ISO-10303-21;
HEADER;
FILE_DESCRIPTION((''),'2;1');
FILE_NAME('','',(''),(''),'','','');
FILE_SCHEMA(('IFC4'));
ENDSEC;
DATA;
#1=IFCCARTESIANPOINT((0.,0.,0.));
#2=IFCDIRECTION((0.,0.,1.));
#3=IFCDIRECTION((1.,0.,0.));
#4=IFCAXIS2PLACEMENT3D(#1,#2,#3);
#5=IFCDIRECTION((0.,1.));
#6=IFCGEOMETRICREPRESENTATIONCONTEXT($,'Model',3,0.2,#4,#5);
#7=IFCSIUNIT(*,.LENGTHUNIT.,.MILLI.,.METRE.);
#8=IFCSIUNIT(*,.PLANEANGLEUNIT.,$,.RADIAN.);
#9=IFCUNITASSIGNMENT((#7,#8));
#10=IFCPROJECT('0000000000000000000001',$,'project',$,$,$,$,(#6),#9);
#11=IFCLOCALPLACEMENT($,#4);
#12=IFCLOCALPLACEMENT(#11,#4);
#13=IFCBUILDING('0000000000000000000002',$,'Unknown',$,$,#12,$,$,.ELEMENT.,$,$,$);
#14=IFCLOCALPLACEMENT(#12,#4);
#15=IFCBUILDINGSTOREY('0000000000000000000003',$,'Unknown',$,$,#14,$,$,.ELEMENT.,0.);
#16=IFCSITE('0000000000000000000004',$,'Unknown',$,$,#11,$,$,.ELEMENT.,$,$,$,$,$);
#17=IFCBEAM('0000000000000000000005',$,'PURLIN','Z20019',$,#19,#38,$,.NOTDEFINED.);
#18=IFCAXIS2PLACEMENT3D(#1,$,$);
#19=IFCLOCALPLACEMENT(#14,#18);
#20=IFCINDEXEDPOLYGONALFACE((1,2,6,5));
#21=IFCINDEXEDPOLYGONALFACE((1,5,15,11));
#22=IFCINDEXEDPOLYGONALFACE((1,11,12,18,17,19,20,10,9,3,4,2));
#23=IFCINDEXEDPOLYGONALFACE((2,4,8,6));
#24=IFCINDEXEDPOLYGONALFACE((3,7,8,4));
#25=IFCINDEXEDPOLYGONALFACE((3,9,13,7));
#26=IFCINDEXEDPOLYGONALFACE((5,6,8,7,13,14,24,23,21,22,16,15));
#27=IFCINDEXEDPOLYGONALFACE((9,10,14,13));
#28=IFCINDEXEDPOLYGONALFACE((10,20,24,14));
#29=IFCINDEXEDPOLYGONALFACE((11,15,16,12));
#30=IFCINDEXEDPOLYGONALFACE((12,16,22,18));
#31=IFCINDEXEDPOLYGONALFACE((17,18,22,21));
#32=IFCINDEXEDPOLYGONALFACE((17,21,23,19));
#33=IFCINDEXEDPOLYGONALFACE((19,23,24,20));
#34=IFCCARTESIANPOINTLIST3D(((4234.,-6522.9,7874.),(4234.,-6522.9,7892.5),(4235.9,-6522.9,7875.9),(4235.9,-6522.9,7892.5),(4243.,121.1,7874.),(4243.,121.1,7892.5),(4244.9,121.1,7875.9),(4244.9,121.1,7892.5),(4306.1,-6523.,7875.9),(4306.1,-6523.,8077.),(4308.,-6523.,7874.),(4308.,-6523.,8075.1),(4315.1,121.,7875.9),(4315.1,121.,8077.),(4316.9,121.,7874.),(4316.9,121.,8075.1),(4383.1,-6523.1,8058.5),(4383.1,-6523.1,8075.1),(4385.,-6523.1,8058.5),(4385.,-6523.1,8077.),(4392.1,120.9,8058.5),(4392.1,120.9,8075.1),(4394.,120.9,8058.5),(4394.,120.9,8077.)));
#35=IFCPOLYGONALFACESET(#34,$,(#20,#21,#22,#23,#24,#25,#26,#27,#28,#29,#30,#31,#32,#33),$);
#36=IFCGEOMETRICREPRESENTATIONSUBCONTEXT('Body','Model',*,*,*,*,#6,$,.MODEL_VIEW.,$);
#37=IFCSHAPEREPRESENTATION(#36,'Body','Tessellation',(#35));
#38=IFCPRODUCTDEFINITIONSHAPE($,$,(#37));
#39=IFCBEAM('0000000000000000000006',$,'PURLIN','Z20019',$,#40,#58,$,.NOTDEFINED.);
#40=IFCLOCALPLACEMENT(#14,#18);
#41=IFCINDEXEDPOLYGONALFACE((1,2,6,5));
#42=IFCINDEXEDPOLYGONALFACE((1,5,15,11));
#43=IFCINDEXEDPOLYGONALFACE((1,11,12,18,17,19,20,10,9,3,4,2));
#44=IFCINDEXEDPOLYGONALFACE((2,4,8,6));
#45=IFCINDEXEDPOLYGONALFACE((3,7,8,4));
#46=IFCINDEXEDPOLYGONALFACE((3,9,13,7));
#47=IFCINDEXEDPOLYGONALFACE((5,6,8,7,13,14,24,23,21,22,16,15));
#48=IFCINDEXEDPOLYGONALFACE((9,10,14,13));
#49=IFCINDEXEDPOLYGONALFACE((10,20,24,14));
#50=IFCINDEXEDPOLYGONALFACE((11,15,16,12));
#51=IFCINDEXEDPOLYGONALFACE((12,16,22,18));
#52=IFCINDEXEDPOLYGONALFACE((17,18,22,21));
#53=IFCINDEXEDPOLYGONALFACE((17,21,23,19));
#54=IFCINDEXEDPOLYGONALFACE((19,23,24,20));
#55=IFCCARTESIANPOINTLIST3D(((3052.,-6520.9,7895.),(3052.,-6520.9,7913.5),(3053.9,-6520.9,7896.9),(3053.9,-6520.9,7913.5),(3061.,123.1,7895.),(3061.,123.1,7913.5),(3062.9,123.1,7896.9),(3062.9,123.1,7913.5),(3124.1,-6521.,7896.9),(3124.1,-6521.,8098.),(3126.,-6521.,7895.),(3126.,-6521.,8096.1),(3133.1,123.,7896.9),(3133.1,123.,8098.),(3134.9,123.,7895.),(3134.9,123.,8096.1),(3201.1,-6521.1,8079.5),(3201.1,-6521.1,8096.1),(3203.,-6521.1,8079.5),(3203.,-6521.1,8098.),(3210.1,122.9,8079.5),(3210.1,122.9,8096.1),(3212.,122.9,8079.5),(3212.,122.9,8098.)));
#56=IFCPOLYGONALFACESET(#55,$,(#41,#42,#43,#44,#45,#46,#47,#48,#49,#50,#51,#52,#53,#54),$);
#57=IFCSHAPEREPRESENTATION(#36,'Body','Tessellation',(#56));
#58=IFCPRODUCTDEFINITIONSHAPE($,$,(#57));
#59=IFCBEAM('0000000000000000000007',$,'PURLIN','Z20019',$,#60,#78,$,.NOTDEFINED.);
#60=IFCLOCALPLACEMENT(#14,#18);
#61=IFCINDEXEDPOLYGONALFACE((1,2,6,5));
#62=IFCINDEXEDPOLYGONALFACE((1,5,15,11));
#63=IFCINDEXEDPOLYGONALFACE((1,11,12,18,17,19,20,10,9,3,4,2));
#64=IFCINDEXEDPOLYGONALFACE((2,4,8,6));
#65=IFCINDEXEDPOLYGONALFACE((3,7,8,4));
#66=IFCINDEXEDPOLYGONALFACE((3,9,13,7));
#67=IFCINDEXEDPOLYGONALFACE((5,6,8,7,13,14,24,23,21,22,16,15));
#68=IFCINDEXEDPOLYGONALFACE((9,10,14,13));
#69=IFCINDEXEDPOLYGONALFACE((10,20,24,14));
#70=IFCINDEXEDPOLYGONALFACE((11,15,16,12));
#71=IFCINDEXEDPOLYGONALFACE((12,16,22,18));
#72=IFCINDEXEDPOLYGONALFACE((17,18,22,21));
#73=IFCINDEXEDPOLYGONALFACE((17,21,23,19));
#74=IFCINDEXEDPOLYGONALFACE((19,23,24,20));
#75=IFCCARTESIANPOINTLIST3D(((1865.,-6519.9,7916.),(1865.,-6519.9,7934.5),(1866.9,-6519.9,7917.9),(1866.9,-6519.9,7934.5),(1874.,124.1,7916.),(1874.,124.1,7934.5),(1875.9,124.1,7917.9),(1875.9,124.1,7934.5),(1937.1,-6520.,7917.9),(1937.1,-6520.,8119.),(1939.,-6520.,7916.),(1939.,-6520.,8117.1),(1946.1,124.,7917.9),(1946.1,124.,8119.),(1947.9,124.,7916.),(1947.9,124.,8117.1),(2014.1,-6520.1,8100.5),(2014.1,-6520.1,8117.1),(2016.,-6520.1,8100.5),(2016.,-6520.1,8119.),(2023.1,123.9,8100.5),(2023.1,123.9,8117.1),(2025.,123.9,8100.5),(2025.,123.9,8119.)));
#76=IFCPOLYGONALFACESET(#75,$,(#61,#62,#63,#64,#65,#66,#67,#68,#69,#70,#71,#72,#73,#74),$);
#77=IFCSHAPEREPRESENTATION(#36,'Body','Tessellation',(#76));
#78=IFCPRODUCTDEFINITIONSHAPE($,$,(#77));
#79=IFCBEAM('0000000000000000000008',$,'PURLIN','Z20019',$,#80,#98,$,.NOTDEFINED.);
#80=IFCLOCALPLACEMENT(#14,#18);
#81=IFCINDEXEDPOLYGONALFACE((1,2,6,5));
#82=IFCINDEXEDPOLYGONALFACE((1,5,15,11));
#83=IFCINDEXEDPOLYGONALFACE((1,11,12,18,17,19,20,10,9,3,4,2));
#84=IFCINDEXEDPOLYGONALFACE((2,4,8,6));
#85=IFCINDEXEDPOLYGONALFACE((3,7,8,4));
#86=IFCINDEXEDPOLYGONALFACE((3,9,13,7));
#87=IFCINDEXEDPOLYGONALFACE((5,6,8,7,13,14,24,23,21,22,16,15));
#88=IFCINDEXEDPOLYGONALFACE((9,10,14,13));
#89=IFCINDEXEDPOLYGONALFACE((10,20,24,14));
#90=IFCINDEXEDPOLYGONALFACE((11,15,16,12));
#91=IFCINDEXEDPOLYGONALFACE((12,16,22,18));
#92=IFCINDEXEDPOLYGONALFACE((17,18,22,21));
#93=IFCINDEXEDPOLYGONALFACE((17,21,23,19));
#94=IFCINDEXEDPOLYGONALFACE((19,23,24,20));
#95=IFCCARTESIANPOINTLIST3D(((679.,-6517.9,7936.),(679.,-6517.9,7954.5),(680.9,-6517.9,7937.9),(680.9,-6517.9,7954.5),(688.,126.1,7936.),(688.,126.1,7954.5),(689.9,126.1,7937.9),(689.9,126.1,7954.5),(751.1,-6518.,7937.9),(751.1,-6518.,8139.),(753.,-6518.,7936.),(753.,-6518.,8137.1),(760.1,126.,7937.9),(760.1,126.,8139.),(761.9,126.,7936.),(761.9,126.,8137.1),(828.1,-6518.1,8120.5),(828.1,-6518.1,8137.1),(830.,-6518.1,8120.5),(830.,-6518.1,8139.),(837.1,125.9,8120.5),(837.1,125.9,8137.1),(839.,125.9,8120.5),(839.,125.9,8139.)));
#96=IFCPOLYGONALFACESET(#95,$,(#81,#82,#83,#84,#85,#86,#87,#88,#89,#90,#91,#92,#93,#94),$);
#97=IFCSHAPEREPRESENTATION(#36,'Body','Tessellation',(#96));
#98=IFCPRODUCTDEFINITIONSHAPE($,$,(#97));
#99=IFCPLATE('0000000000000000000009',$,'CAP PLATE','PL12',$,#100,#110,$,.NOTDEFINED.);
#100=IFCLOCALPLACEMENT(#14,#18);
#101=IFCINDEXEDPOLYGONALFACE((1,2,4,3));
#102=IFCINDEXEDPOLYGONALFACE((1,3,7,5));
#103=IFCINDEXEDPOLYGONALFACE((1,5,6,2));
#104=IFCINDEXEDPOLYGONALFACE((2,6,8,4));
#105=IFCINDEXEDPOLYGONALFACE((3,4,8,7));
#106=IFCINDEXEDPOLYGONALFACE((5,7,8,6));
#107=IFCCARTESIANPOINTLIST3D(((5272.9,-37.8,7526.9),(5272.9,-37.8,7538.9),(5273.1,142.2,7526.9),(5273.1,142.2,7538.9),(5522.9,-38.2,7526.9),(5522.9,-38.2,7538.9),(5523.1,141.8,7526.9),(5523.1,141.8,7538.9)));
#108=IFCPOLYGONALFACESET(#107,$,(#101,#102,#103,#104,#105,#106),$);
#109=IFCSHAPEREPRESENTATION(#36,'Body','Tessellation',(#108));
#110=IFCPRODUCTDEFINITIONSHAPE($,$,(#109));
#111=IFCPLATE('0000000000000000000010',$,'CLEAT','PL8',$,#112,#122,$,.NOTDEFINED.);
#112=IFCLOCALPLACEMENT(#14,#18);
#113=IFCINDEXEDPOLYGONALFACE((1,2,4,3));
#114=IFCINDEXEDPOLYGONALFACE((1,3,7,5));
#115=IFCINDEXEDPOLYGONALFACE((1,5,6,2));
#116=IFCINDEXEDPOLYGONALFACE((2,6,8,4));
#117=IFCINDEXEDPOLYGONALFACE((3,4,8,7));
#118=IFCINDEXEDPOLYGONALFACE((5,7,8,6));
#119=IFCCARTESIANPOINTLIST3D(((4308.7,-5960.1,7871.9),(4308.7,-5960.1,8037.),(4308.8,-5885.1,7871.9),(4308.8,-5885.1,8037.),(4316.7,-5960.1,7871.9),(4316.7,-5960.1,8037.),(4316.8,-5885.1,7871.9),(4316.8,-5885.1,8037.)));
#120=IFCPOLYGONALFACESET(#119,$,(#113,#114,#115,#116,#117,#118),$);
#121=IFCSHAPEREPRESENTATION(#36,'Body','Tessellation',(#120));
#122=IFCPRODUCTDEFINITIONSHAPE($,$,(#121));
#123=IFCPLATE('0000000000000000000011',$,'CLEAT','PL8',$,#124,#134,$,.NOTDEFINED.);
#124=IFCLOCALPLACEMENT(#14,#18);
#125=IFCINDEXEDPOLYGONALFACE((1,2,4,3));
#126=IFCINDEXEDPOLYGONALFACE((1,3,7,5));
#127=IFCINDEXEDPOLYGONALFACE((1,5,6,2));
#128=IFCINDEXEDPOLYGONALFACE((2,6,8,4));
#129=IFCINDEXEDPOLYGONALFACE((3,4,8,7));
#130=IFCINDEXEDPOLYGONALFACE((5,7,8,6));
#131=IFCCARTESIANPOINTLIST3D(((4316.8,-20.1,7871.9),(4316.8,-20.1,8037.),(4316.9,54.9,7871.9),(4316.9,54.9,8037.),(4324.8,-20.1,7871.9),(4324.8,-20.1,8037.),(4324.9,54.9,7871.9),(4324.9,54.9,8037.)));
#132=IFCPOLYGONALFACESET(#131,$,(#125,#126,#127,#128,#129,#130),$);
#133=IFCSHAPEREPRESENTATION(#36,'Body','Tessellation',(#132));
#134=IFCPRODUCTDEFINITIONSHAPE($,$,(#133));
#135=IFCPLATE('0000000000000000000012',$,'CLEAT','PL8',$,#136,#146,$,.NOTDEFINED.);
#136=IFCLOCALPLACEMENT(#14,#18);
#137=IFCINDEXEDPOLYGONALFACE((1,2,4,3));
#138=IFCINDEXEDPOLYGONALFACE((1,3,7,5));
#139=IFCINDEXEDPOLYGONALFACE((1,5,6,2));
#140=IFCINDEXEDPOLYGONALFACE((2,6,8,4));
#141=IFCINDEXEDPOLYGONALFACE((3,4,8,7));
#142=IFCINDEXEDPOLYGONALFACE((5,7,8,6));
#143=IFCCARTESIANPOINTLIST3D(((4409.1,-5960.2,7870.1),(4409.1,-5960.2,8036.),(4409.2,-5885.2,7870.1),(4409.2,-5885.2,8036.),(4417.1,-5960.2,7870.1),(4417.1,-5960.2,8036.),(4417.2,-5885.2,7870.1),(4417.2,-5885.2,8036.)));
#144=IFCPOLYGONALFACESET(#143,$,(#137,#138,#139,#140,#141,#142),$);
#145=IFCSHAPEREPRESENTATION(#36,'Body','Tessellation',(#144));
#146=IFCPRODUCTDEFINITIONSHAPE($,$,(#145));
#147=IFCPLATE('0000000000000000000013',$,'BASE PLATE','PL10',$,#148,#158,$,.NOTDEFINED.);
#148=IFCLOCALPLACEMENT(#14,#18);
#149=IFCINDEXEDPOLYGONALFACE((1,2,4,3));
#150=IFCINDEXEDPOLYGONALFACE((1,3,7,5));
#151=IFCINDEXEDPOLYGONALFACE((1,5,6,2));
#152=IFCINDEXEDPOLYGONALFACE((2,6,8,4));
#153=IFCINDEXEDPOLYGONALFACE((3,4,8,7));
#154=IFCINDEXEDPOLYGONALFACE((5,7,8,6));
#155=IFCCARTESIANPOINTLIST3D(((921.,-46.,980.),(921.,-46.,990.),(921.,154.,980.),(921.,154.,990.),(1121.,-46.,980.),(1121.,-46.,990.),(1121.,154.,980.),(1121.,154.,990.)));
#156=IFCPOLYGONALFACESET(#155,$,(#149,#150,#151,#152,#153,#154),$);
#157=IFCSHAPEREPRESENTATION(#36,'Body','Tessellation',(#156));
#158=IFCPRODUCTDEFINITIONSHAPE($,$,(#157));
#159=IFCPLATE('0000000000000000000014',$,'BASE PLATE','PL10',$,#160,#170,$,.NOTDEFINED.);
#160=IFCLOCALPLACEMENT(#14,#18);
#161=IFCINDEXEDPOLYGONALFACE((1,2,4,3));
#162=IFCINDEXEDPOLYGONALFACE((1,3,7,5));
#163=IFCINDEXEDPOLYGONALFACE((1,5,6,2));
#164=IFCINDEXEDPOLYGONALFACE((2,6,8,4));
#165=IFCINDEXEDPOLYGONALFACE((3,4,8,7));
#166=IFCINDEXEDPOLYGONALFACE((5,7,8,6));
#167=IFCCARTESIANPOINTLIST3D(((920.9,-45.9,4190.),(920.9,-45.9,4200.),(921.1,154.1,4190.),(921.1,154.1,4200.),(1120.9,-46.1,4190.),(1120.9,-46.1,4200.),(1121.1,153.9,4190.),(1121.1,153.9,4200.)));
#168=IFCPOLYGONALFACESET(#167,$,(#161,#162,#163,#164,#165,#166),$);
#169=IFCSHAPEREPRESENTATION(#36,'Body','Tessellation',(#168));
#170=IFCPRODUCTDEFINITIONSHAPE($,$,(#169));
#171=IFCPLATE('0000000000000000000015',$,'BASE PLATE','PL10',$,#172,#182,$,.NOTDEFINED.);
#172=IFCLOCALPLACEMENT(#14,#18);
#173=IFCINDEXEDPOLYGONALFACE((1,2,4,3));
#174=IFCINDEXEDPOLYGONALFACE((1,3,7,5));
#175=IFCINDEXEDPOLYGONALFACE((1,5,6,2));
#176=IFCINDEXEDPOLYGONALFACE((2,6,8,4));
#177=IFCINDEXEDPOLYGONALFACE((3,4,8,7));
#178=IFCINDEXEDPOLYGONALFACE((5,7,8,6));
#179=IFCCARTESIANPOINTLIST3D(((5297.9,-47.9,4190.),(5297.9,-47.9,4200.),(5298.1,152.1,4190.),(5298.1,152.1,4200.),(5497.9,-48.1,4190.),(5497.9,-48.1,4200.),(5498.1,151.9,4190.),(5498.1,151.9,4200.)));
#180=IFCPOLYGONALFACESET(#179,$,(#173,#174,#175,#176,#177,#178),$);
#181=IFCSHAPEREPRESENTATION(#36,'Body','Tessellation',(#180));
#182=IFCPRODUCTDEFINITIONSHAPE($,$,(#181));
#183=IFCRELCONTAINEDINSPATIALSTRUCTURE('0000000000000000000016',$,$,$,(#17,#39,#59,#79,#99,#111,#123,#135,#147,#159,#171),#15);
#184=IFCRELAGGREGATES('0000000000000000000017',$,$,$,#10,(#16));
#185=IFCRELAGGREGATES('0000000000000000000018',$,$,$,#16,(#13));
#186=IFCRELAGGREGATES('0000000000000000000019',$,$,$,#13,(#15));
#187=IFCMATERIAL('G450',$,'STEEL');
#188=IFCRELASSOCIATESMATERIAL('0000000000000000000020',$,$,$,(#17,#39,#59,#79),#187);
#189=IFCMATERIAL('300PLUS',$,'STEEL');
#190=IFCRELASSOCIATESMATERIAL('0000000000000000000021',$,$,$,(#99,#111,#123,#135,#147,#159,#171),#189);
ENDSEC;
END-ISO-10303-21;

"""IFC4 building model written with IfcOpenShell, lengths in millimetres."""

from ifc_helpers import new_model, si_unit, direction, frame, origin_with_axes, place, context, subcontext, project, spatial, line, indexed_curve, outline, extrude, material, element, save


model = new_model("IFC4")

# Units and contexts
model_context = context("Model", 3, precision=0.2, world=origin_with_axes(), true_north=direction((0.0, 1.0)))
body_context = subcontext(model_context, "Body", "Model", "MODEL_VIEW")
ifc_project = project(units=[si_unit("LENGTHUNIT", "METRE", prefix="MILLI"), si_unit("PLANEANGLEUNIT", "RADIAN")], contexts=[model_context])

# Site, building, storey
site_placement = place(None, origin_with_axes())
site = spatial("IfcSite", under=ifc_project, at=site_placement, Name="Unknown", CompositionType="ELEMENT")
building_placement = place(site_placement, origin_with_axes())
building = spatial("IfcBuilding", under=site, at=building_placement, Name="Unknown", CompositionType="ELEMENT")
storey_placement = place(building_placement, origin_with_axes())
storey = spatial("IfcBuildingStorey", under=building, at=storey_placement, Name="Unknown", CompositionType="ELEMENT", Elevation=0.0)

# Beams
ifc_material_1 = material(Name="G450", Category="STEEL")
for number, where, z_axis, x_axis, name in (
    (1, (4316.0, 121.0, 7975.5), (-0.999999, 0.001355, 0.0), (-0.001355, -0.999999, 0.0), "PURLIN"),
    (2, (3134.0, 123.0, 7996.5), (-0.999999, 0.001355, 0.0), (-0.001355, -0.999999, 0.0), "PURLIN"),
    (3, (1947.0, 124.0, 8017.5), (-0.999999, 0.001355, 0.0), (-0.001355, -0.999999, 0.0), "PURLIN"),
    (4, (761.0, 126.0, 8037.5), (-0.999999, 0.001355, 0.0), (-0.001355, -0.999999, 0.0), "PURLIN"),
):
    element("IfcBeam", number, at=place(storey_placement, frame(where, z_axis=z_axis, x_axis=x_axis)), inside=storey, material=ifc_material_1, Name=name, Description="Z20019", PredefinedType="NOTDEFINED", context=body_context, shape_type="SolidModel", body=[
        extrude(outline(indexed_curve([(73.0, -101.5), (73.0, -83.0), (71.2, -83.0), (71.2, -99.6), (0.9, -99.6), (0.9, 101.5), (-78.0, 101.5), (-78.0, 83.0), (-76.2, 83.0), (-76.2, 99.6), (-0.9, 99.6), (-0.9, -101.5)], segments=[line(1, 2, 3, 4, 5, 6, 7, 8, 9, 10, 11, 12, 1)])), frame((0.0, 0.0, 0.0), z_axis=(-1.0, 0.0, 0.0), x_axis=(0.0, 0.0, 1.0)), (0.0, 0.0, -1.0), 6644.0),
    ])

# Plates
ifc_material_2 = material(Name="300PLUS", Category="STEEL")
plate_1_placement = place(storey_placement, frame((5272.9, -37.8, 7532.9), z_axis=(0.0, 0.0, 1.0), x_axis=(0.999999, -0.0016, 0.0)))
element("IfcPlate", 5, at=plate_1_placement, inside=storey, material=ifc_material_2, Name="CAP PLATE", Description="PL12", PredefinedType="NOTDEFINED", context=body_context, shape_type="SolidModel", body=[
    extrude(outline(indexed_curve([(0.0, 0.0), (250.0, 0.0), (249.9, 180.0), (-0.1, 180.0)], segments=[line(1, 2, 3, 4, 1)])), frame((0.0, 0.0, 6.0), z_axis=(0.0, 0.0, 1.0), x_axis=(1.0, 0.0, 0.0)), (0.0, 0.0, -1.0), 12.0),
])
for number, where, z_axis, x_axis, name in (
    (6, (4312.8, -5885.1, 8037.0), (0.999999, -0.001333, 0.0), (-0.001333, -0.999999, 0.0), "CLEAT"),
    (7, (4320.9, 54.9, 8037.0), (0.999999, -0.001333, 0.0), (-0.001333, -0.999999, 0.0), "CLEAT"),
):
    element("IfcPlate", number, at=place(storey_placement, frame(where, z_axis=z_axis, x_axis=x_axis)), inside=storey, material=ifc_material_2, Name=name, Description="PL8", PredefinedType="NOTDEFINED", context=body_context, shape_type="SolidModel", body=[
        extrude(outline(indexed_curve([(0.0, 0.0), (75.0, 0.0), (75.0, 165.1), (0.0, 165.1)], segments=[line(1, 2, 3, 4, 1)])), frame((0.0, 0.0, 4.0), z_axis=(0.0, 0.0, 1.0), x_axis=(1.0, 0.0, 0.0)), (0.0, 0.0, -1.0), 8.0),
    ])
plate_2_placement = place(storey_placement, frame((4413.2, -5885.2, 8036.0), z_axis=(0.999999, -0.001333, 0.0), x_axis=(-0.001333, -0.999999, 0.0)))
element("IfcPlate", 8, at=plate_2_placement, inside=storey, material=ifc_material_2, Name="CLEAT", Description="PL8", PredefinedType="NOTDEFINED", context=body_context, shape_type="SolidModel", body=[
    extrude(outline(indexed_curve([(0.0, 0.0), (75.0, 0.0), (75.0, 165.9), (0.0, 165.9)], segments=[line(1, 2, 3, 4, 1)])), frame((0.0, 0.0, 4.0), z_axis=(0.0, 0.0, 1.0), x_axis=(1.0, 0.0, 0.0)), (0.0, 0.0, -1.0), 8.0),
])
plate_3_placement = place(storey_placement, frame((921.0, -46.0, 985.0), z_axis=(0.0, 0.0, 1.0), x_axis=(1.0, 0.0, 0.0)))
element("IfcPlate", 9, at=plate_3_placement, inside=storey, material=ifc_material_2, Name="BASE PLATE", Description="PL10", PredefinedType="NOTDEFINED", context=body_context, shape_type="SolidModel", body=[
    extrude(outline(indexed_curve([(0.0, 0.0), (200.0, 0.0), (200.0, 200.0), (0.0, 200.0)], segments=[line(1, 2, 3, 4, 1)])), frame((0.0, 0.0, 5.0), z_axis=(0.0, 0.0, 1.0), x_axis=(1.0, 0.0, 0.0)), (0.0, 0.0, -1.0), 10.0),
])
for number, where, z_axis, x_axis, name in (
    (10, (920.9, -45.9, 4195.0), (0.0, 0.0, 1.0), (1.0, -0.001, 0.0), "BASE PLATE"),
    (11, (5297.9, -47.9, 4195.0), (0.0, 0.0, 1.0), (1.0, -0.001, 0.0), "BASE PLATE"),
):
    element("IfcPlate", number, at=place(storey_placement, frame(where, z_axis=z_axis, x_axis=x_axis)), inside=storey, material=ifc_material_2, Name=name, Description="PL10", PredefinedType="NOTDEFINED", context=body_context, shape_type="SolidModel", body=[
        extrude(outline(indexed_curve([(0.0, 0.0), (200.0, 0.0), (200.0, 200.0), (0.0, 200.0)], segments=[line(1, 2, 3, 4, 1)])), frame((0.0, 0.0, 5.0), z_axis=(0.0, 0.0, 1.0), x_axis=(1.0, 0.0, 0.0)), (0.0, 0.0, -1.0), 10.0),
    ])

save(model, "model.ifc")
